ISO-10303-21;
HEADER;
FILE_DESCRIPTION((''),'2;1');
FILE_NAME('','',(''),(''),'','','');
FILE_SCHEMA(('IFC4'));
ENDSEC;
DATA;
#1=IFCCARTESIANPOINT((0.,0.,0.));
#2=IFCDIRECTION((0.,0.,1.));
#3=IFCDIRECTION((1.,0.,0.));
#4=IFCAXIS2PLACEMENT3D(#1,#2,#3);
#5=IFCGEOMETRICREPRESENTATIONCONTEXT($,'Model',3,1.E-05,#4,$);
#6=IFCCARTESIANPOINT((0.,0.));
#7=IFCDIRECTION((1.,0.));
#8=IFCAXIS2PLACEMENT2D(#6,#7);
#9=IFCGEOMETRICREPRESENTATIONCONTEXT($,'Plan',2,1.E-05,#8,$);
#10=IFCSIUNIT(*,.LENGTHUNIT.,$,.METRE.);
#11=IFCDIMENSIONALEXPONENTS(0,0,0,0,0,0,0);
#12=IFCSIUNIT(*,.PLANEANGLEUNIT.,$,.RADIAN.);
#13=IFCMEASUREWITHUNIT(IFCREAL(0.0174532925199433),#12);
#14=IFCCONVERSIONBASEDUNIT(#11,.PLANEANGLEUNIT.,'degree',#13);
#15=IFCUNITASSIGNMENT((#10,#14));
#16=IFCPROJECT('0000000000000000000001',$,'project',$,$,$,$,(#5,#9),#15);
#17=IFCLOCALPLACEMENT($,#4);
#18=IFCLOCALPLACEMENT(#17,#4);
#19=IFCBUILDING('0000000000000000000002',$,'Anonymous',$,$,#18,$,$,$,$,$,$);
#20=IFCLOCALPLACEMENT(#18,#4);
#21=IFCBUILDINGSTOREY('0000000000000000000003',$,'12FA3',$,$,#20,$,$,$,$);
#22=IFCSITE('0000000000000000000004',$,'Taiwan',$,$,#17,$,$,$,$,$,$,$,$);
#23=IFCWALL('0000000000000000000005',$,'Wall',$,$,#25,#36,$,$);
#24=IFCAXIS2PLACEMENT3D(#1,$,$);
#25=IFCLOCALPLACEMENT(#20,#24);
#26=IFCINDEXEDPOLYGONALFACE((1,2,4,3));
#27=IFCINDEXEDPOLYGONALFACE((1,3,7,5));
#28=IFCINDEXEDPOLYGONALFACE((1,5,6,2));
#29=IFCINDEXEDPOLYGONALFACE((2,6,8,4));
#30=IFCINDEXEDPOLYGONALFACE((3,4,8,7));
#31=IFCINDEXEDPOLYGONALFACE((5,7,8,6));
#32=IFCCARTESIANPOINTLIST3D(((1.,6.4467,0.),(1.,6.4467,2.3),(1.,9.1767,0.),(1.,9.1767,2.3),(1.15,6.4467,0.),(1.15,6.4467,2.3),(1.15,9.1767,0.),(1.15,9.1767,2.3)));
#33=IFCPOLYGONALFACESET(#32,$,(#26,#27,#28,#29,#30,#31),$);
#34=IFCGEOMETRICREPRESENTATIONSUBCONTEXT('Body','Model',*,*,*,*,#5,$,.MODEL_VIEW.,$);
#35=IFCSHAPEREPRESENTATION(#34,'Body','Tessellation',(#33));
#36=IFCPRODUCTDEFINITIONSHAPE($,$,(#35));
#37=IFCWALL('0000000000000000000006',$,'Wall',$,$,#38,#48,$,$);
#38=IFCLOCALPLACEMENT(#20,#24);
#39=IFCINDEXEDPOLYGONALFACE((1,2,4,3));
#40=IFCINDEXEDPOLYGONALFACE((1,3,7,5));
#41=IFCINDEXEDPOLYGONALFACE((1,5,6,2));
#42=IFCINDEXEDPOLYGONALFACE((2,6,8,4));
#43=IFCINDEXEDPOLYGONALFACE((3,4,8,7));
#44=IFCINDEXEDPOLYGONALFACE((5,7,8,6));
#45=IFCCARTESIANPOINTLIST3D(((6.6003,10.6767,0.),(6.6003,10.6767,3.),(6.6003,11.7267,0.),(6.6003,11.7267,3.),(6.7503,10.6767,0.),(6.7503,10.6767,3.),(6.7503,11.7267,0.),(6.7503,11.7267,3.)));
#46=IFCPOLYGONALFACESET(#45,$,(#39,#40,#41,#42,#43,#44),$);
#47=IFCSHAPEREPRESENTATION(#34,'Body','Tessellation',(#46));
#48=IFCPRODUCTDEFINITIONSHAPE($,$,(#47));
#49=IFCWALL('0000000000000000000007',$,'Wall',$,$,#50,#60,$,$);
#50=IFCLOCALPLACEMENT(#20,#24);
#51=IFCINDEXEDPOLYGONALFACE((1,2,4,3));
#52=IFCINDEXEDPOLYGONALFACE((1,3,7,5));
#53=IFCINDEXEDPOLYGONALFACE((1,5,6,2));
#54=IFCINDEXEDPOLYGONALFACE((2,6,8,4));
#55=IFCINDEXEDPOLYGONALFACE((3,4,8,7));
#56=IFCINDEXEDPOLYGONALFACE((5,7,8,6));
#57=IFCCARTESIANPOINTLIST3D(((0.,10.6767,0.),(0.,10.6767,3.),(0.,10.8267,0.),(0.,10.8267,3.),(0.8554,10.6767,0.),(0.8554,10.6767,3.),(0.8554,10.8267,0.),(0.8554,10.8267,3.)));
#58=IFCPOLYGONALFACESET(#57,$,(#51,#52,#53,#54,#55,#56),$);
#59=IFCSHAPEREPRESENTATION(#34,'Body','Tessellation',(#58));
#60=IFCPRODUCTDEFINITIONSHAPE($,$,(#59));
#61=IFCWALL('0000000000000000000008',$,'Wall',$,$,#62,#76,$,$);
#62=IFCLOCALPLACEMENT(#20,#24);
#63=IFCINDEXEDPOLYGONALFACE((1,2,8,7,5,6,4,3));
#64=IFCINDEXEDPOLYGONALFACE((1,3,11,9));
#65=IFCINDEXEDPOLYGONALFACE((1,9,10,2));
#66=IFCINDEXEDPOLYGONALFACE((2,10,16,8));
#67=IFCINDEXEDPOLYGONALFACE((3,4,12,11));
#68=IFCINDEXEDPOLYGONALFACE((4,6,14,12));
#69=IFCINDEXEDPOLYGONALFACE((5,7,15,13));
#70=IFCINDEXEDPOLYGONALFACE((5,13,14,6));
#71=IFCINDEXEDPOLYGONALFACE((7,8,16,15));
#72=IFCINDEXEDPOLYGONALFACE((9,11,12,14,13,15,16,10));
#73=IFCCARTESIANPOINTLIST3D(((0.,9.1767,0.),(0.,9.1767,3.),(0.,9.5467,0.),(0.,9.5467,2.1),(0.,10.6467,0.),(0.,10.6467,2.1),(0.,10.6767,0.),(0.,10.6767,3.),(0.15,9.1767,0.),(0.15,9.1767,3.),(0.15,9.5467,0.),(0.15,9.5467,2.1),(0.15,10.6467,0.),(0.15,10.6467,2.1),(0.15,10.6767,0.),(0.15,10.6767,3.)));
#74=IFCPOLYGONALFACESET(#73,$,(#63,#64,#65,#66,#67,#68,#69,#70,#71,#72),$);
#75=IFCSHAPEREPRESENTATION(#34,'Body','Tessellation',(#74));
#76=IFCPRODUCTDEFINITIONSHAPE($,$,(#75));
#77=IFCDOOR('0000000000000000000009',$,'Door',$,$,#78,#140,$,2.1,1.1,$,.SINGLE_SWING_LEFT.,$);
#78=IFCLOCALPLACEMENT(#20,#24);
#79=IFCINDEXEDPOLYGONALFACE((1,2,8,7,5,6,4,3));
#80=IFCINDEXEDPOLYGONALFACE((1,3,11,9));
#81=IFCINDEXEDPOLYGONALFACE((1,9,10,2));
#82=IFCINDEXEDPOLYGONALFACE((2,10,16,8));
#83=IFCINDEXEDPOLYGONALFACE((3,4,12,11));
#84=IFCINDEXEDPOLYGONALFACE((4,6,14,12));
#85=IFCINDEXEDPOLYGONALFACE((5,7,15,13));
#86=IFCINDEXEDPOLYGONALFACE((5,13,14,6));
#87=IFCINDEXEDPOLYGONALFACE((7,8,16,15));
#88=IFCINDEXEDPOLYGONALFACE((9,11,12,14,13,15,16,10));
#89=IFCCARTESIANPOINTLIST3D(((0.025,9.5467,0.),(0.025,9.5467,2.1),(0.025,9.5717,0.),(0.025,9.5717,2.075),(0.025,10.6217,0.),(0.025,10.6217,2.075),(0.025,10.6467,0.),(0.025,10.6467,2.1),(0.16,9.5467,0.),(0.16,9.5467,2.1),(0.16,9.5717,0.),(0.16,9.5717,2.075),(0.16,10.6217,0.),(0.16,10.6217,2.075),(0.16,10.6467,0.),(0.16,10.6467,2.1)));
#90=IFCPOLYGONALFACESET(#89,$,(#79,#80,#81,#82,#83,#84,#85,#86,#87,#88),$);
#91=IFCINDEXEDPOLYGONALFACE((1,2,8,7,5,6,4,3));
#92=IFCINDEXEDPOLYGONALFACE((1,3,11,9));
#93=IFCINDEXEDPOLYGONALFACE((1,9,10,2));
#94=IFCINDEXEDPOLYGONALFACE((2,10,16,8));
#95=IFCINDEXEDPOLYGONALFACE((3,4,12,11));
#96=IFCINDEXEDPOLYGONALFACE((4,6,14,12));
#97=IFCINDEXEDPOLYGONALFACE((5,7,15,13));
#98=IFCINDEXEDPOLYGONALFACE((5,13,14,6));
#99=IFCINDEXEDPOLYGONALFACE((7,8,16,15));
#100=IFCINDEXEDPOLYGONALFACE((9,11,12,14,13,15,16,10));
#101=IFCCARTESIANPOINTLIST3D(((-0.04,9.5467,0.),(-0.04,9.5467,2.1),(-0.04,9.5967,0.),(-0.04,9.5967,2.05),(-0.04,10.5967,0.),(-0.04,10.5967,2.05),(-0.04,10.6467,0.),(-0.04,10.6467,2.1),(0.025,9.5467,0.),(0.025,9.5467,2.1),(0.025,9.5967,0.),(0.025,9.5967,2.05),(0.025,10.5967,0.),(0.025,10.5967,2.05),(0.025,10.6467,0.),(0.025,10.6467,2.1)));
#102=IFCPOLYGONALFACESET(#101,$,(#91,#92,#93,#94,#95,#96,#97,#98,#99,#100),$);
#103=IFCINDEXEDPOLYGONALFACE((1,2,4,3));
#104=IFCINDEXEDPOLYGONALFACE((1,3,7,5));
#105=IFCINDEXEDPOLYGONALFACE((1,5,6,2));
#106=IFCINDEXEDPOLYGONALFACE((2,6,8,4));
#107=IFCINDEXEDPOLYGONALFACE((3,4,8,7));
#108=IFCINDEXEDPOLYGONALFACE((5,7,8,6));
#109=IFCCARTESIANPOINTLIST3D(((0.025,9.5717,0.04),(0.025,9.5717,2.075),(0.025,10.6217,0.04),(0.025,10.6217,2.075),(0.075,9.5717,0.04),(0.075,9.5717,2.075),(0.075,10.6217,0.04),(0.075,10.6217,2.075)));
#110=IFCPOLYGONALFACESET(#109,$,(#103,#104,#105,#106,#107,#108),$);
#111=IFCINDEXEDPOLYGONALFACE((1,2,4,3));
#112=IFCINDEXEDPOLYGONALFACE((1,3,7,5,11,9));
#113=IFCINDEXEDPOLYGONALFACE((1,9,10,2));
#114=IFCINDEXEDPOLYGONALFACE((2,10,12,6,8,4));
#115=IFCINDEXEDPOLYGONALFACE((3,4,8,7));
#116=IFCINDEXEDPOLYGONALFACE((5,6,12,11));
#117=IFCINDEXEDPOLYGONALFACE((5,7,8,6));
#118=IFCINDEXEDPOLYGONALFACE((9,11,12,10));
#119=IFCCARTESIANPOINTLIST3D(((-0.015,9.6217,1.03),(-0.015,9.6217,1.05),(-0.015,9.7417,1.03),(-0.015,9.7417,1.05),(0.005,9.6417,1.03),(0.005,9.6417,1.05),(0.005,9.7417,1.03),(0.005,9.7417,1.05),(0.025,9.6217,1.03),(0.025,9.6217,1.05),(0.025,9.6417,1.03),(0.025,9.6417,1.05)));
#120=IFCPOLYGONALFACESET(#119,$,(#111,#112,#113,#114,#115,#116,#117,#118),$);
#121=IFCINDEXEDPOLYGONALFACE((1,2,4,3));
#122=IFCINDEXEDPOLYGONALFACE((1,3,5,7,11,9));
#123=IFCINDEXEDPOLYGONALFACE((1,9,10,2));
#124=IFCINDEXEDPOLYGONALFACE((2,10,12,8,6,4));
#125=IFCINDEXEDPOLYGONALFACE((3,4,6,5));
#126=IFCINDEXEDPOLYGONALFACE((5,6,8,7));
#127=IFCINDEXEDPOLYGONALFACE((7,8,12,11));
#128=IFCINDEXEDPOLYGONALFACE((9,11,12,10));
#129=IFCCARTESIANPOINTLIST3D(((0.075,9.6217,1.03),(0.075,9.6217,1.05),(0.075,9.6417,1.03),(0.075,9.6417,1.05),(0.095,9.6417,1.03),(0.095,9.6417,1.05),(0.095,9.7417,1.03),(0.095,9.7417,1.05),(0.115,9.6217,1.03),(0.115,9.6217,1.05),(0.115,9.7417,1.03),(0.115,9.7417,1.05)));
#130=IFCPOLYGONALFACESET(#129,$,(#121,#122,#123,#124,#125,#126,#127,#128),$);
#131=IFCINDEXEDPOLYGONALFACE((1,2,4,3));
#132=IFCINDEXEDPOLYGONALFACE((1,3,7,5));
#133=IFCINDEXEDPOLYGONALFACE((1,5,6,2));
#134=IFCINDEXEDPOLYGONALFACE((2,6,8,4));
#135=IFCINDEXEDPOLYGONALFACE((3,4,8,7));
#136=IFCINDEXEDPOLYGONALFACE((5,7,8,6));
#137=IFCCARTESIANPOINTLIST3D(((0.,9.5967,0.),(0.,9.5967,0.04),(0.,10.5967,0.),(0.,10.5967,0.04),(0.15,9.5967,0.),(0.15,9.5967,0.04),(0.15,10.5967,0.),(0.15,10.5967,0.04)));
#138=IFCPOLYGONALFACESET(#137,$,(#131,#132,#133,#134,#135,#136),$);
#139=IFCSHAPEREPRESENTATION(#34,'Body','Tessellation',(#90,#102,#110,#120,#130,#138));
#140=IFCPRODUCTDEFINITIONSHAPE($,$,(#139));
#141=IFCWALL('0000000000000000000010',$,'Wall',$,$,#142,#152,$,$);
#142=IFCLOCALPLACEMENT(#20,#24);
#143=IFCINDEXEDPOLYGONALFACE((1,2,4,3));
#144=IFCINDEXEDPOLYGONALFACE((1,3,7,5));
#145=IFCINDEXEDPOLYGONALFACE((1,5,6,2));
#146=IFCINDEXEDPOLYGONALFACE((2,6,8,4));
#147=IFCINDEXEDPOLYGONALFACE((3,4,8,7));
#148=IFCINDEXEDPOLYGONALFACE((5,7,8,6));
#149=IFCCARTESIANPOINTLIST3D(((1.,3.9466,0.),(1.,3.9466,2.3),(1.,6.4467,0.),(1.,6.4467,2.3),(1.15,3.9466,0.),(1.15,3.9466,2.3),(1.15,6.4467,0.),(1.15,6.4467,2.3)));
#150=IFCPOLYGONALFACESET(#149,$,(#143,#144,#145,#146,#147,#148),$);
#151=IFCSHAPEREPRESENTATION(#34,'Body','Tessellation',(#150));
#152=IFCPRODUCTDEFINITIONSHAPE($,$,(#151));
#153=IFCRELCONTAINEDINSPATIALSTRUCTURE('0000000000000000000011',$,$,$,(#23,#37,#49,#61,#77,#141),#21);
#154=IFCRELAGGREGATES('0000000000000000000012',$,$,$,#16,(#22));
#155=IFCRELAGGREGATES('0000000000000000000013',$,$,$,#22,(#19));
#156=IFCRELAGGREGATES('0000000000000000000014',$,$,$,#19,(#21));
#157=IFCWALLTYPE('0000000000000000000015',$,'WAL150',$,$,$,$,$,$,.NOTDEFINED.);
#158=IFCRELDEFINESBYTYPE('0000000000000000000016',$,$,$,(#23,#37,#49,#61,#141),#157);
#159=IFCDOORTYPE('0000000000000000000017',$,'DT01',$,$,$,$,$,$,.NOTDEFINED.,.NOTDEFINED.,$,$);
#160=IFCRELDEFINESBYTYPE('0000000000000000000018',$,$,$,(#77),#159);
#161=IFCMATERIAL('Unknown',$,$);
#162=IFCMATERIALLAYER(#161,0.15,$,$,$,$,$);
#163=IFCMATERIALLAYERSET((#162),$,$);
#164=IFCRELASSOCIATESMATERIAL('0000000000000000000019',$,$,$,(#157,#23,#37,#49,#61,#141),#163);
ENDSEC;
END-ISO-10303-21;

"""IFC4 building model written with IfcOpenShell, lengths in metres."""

from ifc_helpers import new_model, entity, si_unit, converted_unit, frame, origin_with_axes, origin_2d_with_axis, place, context, subcontext, project, spatial, line, indexed_curve, outline, extrude, shape, source, transform, mapped, material, layer, layer_set, layer_usage, type_object, type_shapes, element, fill, save


model = new_model("IFC4")

# Units and contexts
model_context = context("Model", 3, precision=1e-05, world=origin_with_axes())
plan_context = context("Plan", 2, precision=1e-05, world=origin_2d_with_axis())
body_context_1 = subcontext(model_context, "Body", "Model", "MODEL_VIEW")
body_context_2 = subcontext(plan_context, "Body", "Plan", "PLAN_VIEW")
ifc_project = project(units=[si_unit("LENGTHUNIT", "METRE"), converted_unit("PLANEANGLEUNIT", "degree", entity("IfcReal", 0.0174532925199433), si_unit("PLANEANGLEUNIT", "RADIAN"), dimensions=[0, 0, 0, 0, 0, 0, 0])], contexts=[model_context, plan_context])

# Site, building, storey
site_placement = place(None, origin_with_axes())
site = spatial("IfcSite", under=ifc_project, at=site_placement, Name="Taiwan")
building_placement = place(site_placement, origin_with_axes())
building = spatial("IfcBuilding", under=site, at=building_placement, Name="Anonymous")
storey_placement = place(building_placement, origin_with_axes())
storey = spatial("IfcBuildingStorey", under=building, at=storey_placement, Name="12FA3")

# Shared definitions
ifc_material = material(Name="Unknown")

# Walls
ifc_layer_1 = layer(ifc_material, 0.15)
ifc_layer_set_1 = layer_set([ifc_layer_1])
wall_type_1 = type_object("IfcWallType", Name="WAL150", PredefinedType="NOTDEFINED", material=ifc_layer_set_1)
ifc_layer_usage_1 = layer_usage(ifc_layer_set_1, "AXIS2", "POSITIVE", 0.0)
wall_1_placement = place(storey_placement, frame((1.0, 9.1767, 0.0), z_axis=(0.0, 0.0, 1.0), x_axis=(0.0, -1.0, 0.0)))
element("IfcWall", 1, at=wall_1_placement, inside=storey, type_object=wall_type_1, material=ifc_layer_usage_1, Name="Wall", context=body_context_1, shape_type="SweptSolid", body=[
    extrude(outline(indexed_curve([(0.0, 0.0), (0.0, 0.15), (2.73, 0.15), (2.73, 0.0)], segments=[line(1, 2, 3, 4, 1)])), origin_with_axes(), (0.0, 0.0, 1.0), 2.3),
])
ifc_layer_usage_2 = layer_usage(ifc_layer_set_1, "AXIS2", "POSITIVE", 0.0)
wall_2_placement = place(storey_placement, frame((6.6003, 11.7267, 0.0), z_axis=(0.0, 0.0, 1.0), x_axis=(0.0, -1.0, 0.0)))
element("IfcWall", 2, at=wall_2_placement, inside=storey, type_object=wall_type_1, material=ifc_layer_usage_2, Name="Wall", context=body_context_1, shape_type="SweptSolid", body=[
    extrude(outline(indexed_curve([(0.0, 0.0), (0.0, 0.15), (1.05, 0.15), (1.05, 0.0)], segments=[line(1, 2, 3, 4, 1)])), origin_with_axes(), (0.0, 0.0, 1.0), 3.0),
])

# Wall
ifc_layer_usage_3 = layer_usage(ifc_layer_set_1, "AXIS2", "POSITIVE", 0.0)
wall_3_placement = place(storey_placement, frame((0.8554, 10.8267, 0.0), z_axis=(0.0, 0.0, 1.0), x_axis=(-1.0, 0.0, 0.0)))
element("IfcWall", 3, at=wall_3_placement, inside=storey, type_object=wall_type_1, material=ifc_layer_usage_3, Name="Wall", context=body_context_1, shape_type="SweptSolid", body=[
    extrude(outline(indexed_curve([(0.0, 0.0), (0.0, 0.15), (0.8553, 0.15), (0.8553, 0.0)], segments=[line(1, 2, 3, 4, 1)])), origin_with_axes(), (0.0, 0.0, 1.0), 3.0),
])

# Wall, opening, door
ifc_layer_usage_4 = layer_usage(ifc_layer_set_1, "AXIS2", "POSITIVE", 0.0)
wall_4_placement = place(storey_placement, frame((0.0, 10.6767, 0.0), z_axis=(0.0, 0.0, 1.0), x_axis=(0.0, -1.0, 0.0)))
wall_4 = element("IfcWall", 4, at=wall_4_placement, inside=storey, type_object=wall_type_1, material=ifc_layer_usage_4, Name="Wall", context=body_context_1, shape_type="SweptSolid", body=[
    extrude(outline(indexed_curve([(0.0, 0.0), (0.0, 0.15), (1.5, 0.15), (1.5, 0.0)], segments=[line(1, 2, 3, 4, 1)])), origin_with_axes(), (0.0, 0.0, 1.0), 3.0),
])
shared_shape_1 = source(origin_with_axes(), body_context_1, "Body", "SweptSolid", [
    extrude(outline(indexed_curve([(0.0, 0.0), (1.1, 0.0), (1.1, 2.1), (0.0, 2.1)], segments=[line(1, 2, 3, 4, 1)])), frame((0.0, -0.6, 0.0), z_axis=(0.0, -1.0, 0.0), x_axis=(1.0, 0.0, 0.0)), (0.0, 0.0, -1.0), 1.2),
])
opening_1_placement = place(wall_4_placement, frame((0.03, 0.0, 0.0), z_axis=(0.0, 0.0, 1.0), x_axis=(1.0, 0.0, 0.0)))
opening_1 = element("IfcOpeningElement", 5, at=opening_1_placement, cuts=wall_4, PredefinedType="OPENING", context=body_context_1, shape_type="MappedRepresentation", body=[
    mapped(shared_shape_1, transform((0.0, 0.0, 0.0), x_axis=(1.0, 0.0, 0.0), y_axis=(0.0, 1.0, 0.0), z_axis=(0.0, 0.0, 1.0), scale=1.0)),
])
door_type_1 = type_object("IfcDoorType", Name="DT01", OperationType="NOTDEFINED", PredefinedType="NOTDEFINED")
shared_shape_2 = source(origin_with_axes(), body_context_1, "Body", "SweptSolid", [
    extrude(outline(indexed_curve([(0.0, 0.0), (0.0, 2.1), (1.1, 2.1), (1.1, 0.0), (1.075, 0.0), (1.075, 2.075), (0.025, 2.075), (0.025, 0.0)], segments=[line(1, 2, 3, 4, 5, 6, 7, 8, 1)])), frame((0.0, 0.025, 0.0), z_axis=(0.0, -1.0, 0.0), x_axis=(1.0, 0.0, 0.0)), (0.0, 0.0, -1.0), 0.135),
    extrude(outline(indexed_curve([(0.0, 0.0), (0.0, 2.1), (1.1, 2.1), (1.1, 0.0), (1.05, 0.0), (1.05, 2.05), (0.05, 2.05), (0.05, 0.0)], segments=[line(1, 2, 3, 4, 5, 6, 7, 8, 1)])), frame((0.0, -0.04, 0.0), z_axis=(0.0, -1.0, 0.0), x_axis=(1.0, 0.0, 0.0)), (0.0, 0.0, -1.0), 0.065),
    extrude(outline(indexed_curve([(0.0, 0.0), (1.05, 0.0), (1.05, 0.05), (0.0, 0.05)], segments=[line(1, 2, 3, 4, 1)])), frame((0.025, 0.025, 0.04), z_axis=(0.0, 0.0, 1.0), x_axis=(1.0, 0.0, 0.0)), (0.0, 0.0, 1.0), 2.035),
    extrude(outline(indexed_curve([(0.0, 0.0), (0.0, -0.04), (-0.12, -0.04), (-0.12, -0.02), (-0.02, -0.02), (-0.02, 0.0)], segments=[line(1, 2, 3, 4, 5, 6, 1)])), frame((1.025, 0.025, 1.03), z_axis=(0.0, 0.0, 1.0), x_axis=(1.0, 0.0, 0.0)), (0.0, 0.0, 1.0), 0.02),
    extrude(outline(indexed_curve([(0.0, 0.0), (0.0, 0.04), (-0.12, 0.04), (-0.12, 0.02), (-0.02, 0.02), (-0.02, 0.0)], segments=[line(1, 2, 3, 4, 5, 6, 1)])), frame((1.025, 0.075, 1.03), z_axis=(0.0, 0.0, 1.0), x_axis=(1.0, 0.0, 0.0)), (0.0, 0.0, 1.0), 0.02),
    extrude(outline(indexed_curve([(0.0, 0.0), (1.0, 0.0), (1.0, 0.15), (0.0, 0.15)], segments=[line(1, 2, 3, 4, 1)])), frame((0.05, 0.0, 0.0), z_axis=(0.0, 0.0, 1.0), x_axis=(1.0, 0.0, 0.0)), (0.0, 0.0, 1.0), 0.04),
])
shared_shape_3 = source(origin_with_axes(), body_context_2, "Body", "Curve2D", [
    entity("IfcIndexedPolyCurve", entity("IfcCartesianPointList2D", [[0.0, -0.04], [0.0, 0.16], [0.025, 0.16], [0.025, 0.025], [0.05, 0.025], [0.05, -0.04]]), [entity("IfcLineIndex", [1, 2, 3, 4, 5, 6, 1])]),
    entity("IfcIndexedPolyCurve", entity("IfcCartesianPointList2D", [[1.1, -0.04], [1.1, 0.16], [1.075, 0.16], [1.075, 0.025], [1.05, 0.025], [1.05, -0.04]]), [entity("IfcLineIndex", [1, 2, 3, 4, 5, 6, 1])]),
    entity("IfcTrimmedCurve", entity("IfcEllipse", entity("IfcAxis2Placement2D", entity("IfcCartesianPoint", [0.075, 0.16]), entity("IfcDirection", [1.0, 0.0])), 1.0, 1.05), [entity("IfcCartesianPoint", [1.075, 0.16])], [entity("IfcCartesianPoint", [0.075, 1.21])], True, "CARTESIAN"),
    entity("IfcIndexedPolyCurve", entity("IfcCartesianPointList2D", [[0.025, 0.16], [0.075, 0.16], [0.075, 1.21], [0.025, 1.21]]), [entity("IfcLineIndex", [1, 2, 3, 4, 1])]),
])
type_shapes(door_type_1, [shared_shape_2, shared_shape_3])
door_1_placement = place(opening_1_placement, frame((0.0, 0.0, 0.0), z_axis=(0.0, 0.0, 1.0), x_axis=(1.0, 0.0, 0.0)))
door_1 = element("IfcDoor", 6, at=door_1_placement, inside=storey, type_object=door_type_1, Name="Door", OperationType="SINGLE_SWING_LEFT", OverallHeight=2.1, OverallWidth=1.1, shapes=[
    shape(body_context_1, "Body", "MappedRepresentation", [mapped(shared_shape_2, transform((0.0, 0.0, 0.0), x_axis=(1.0, 0.0, 0.0), y_axis=(0.0, 1.0, 0.0), z_axis=(0.0, 0.0, 1.0), scale=1.0))]),
    shape(body_context_2, "Body", "MappedRepresentation", [mapped(shared_shape_3, transform((0.0, 0.0, 0.0), x_axis=(1.0, 0.0, 0.0), y_axis=(0.0, 1.0, 0.0), z_axis=(0.0, 0.0, 1.0), scale=1.0))]),
])
fill(opening_1, door_1)

# Wall
ifc_layer_usage_5 = layer_usage(ifc_layer_set_1, "AXIS2", "POSITIVE", 0.0)
wall_5_placement = place(storey_placement, frame((1.0, 6.4467, 0.0), z_axis=(0.0, 0.0, 1.0), x_axis=(0.0, -1.0, 0.0)))
element("IfcWall", 7, at=wall_5_placement, inside=storey, type_object=wall_type_1, material=ifc_layer_usage_5, Name="Wall", context=body_context_1, shape_type="SweptSolid", body=[
    extrude(outline(indexed_curve([(0.0, 0.0), (0.0, 0.15), (2.5001, 0.15), (2.5001, 0.0)], segments=[line(1, 2, 3, 4, 1)])), origin_with_axes(), (0.0, 0.0, 1.0), 2.3),
])

save(model, "model.ifc")
